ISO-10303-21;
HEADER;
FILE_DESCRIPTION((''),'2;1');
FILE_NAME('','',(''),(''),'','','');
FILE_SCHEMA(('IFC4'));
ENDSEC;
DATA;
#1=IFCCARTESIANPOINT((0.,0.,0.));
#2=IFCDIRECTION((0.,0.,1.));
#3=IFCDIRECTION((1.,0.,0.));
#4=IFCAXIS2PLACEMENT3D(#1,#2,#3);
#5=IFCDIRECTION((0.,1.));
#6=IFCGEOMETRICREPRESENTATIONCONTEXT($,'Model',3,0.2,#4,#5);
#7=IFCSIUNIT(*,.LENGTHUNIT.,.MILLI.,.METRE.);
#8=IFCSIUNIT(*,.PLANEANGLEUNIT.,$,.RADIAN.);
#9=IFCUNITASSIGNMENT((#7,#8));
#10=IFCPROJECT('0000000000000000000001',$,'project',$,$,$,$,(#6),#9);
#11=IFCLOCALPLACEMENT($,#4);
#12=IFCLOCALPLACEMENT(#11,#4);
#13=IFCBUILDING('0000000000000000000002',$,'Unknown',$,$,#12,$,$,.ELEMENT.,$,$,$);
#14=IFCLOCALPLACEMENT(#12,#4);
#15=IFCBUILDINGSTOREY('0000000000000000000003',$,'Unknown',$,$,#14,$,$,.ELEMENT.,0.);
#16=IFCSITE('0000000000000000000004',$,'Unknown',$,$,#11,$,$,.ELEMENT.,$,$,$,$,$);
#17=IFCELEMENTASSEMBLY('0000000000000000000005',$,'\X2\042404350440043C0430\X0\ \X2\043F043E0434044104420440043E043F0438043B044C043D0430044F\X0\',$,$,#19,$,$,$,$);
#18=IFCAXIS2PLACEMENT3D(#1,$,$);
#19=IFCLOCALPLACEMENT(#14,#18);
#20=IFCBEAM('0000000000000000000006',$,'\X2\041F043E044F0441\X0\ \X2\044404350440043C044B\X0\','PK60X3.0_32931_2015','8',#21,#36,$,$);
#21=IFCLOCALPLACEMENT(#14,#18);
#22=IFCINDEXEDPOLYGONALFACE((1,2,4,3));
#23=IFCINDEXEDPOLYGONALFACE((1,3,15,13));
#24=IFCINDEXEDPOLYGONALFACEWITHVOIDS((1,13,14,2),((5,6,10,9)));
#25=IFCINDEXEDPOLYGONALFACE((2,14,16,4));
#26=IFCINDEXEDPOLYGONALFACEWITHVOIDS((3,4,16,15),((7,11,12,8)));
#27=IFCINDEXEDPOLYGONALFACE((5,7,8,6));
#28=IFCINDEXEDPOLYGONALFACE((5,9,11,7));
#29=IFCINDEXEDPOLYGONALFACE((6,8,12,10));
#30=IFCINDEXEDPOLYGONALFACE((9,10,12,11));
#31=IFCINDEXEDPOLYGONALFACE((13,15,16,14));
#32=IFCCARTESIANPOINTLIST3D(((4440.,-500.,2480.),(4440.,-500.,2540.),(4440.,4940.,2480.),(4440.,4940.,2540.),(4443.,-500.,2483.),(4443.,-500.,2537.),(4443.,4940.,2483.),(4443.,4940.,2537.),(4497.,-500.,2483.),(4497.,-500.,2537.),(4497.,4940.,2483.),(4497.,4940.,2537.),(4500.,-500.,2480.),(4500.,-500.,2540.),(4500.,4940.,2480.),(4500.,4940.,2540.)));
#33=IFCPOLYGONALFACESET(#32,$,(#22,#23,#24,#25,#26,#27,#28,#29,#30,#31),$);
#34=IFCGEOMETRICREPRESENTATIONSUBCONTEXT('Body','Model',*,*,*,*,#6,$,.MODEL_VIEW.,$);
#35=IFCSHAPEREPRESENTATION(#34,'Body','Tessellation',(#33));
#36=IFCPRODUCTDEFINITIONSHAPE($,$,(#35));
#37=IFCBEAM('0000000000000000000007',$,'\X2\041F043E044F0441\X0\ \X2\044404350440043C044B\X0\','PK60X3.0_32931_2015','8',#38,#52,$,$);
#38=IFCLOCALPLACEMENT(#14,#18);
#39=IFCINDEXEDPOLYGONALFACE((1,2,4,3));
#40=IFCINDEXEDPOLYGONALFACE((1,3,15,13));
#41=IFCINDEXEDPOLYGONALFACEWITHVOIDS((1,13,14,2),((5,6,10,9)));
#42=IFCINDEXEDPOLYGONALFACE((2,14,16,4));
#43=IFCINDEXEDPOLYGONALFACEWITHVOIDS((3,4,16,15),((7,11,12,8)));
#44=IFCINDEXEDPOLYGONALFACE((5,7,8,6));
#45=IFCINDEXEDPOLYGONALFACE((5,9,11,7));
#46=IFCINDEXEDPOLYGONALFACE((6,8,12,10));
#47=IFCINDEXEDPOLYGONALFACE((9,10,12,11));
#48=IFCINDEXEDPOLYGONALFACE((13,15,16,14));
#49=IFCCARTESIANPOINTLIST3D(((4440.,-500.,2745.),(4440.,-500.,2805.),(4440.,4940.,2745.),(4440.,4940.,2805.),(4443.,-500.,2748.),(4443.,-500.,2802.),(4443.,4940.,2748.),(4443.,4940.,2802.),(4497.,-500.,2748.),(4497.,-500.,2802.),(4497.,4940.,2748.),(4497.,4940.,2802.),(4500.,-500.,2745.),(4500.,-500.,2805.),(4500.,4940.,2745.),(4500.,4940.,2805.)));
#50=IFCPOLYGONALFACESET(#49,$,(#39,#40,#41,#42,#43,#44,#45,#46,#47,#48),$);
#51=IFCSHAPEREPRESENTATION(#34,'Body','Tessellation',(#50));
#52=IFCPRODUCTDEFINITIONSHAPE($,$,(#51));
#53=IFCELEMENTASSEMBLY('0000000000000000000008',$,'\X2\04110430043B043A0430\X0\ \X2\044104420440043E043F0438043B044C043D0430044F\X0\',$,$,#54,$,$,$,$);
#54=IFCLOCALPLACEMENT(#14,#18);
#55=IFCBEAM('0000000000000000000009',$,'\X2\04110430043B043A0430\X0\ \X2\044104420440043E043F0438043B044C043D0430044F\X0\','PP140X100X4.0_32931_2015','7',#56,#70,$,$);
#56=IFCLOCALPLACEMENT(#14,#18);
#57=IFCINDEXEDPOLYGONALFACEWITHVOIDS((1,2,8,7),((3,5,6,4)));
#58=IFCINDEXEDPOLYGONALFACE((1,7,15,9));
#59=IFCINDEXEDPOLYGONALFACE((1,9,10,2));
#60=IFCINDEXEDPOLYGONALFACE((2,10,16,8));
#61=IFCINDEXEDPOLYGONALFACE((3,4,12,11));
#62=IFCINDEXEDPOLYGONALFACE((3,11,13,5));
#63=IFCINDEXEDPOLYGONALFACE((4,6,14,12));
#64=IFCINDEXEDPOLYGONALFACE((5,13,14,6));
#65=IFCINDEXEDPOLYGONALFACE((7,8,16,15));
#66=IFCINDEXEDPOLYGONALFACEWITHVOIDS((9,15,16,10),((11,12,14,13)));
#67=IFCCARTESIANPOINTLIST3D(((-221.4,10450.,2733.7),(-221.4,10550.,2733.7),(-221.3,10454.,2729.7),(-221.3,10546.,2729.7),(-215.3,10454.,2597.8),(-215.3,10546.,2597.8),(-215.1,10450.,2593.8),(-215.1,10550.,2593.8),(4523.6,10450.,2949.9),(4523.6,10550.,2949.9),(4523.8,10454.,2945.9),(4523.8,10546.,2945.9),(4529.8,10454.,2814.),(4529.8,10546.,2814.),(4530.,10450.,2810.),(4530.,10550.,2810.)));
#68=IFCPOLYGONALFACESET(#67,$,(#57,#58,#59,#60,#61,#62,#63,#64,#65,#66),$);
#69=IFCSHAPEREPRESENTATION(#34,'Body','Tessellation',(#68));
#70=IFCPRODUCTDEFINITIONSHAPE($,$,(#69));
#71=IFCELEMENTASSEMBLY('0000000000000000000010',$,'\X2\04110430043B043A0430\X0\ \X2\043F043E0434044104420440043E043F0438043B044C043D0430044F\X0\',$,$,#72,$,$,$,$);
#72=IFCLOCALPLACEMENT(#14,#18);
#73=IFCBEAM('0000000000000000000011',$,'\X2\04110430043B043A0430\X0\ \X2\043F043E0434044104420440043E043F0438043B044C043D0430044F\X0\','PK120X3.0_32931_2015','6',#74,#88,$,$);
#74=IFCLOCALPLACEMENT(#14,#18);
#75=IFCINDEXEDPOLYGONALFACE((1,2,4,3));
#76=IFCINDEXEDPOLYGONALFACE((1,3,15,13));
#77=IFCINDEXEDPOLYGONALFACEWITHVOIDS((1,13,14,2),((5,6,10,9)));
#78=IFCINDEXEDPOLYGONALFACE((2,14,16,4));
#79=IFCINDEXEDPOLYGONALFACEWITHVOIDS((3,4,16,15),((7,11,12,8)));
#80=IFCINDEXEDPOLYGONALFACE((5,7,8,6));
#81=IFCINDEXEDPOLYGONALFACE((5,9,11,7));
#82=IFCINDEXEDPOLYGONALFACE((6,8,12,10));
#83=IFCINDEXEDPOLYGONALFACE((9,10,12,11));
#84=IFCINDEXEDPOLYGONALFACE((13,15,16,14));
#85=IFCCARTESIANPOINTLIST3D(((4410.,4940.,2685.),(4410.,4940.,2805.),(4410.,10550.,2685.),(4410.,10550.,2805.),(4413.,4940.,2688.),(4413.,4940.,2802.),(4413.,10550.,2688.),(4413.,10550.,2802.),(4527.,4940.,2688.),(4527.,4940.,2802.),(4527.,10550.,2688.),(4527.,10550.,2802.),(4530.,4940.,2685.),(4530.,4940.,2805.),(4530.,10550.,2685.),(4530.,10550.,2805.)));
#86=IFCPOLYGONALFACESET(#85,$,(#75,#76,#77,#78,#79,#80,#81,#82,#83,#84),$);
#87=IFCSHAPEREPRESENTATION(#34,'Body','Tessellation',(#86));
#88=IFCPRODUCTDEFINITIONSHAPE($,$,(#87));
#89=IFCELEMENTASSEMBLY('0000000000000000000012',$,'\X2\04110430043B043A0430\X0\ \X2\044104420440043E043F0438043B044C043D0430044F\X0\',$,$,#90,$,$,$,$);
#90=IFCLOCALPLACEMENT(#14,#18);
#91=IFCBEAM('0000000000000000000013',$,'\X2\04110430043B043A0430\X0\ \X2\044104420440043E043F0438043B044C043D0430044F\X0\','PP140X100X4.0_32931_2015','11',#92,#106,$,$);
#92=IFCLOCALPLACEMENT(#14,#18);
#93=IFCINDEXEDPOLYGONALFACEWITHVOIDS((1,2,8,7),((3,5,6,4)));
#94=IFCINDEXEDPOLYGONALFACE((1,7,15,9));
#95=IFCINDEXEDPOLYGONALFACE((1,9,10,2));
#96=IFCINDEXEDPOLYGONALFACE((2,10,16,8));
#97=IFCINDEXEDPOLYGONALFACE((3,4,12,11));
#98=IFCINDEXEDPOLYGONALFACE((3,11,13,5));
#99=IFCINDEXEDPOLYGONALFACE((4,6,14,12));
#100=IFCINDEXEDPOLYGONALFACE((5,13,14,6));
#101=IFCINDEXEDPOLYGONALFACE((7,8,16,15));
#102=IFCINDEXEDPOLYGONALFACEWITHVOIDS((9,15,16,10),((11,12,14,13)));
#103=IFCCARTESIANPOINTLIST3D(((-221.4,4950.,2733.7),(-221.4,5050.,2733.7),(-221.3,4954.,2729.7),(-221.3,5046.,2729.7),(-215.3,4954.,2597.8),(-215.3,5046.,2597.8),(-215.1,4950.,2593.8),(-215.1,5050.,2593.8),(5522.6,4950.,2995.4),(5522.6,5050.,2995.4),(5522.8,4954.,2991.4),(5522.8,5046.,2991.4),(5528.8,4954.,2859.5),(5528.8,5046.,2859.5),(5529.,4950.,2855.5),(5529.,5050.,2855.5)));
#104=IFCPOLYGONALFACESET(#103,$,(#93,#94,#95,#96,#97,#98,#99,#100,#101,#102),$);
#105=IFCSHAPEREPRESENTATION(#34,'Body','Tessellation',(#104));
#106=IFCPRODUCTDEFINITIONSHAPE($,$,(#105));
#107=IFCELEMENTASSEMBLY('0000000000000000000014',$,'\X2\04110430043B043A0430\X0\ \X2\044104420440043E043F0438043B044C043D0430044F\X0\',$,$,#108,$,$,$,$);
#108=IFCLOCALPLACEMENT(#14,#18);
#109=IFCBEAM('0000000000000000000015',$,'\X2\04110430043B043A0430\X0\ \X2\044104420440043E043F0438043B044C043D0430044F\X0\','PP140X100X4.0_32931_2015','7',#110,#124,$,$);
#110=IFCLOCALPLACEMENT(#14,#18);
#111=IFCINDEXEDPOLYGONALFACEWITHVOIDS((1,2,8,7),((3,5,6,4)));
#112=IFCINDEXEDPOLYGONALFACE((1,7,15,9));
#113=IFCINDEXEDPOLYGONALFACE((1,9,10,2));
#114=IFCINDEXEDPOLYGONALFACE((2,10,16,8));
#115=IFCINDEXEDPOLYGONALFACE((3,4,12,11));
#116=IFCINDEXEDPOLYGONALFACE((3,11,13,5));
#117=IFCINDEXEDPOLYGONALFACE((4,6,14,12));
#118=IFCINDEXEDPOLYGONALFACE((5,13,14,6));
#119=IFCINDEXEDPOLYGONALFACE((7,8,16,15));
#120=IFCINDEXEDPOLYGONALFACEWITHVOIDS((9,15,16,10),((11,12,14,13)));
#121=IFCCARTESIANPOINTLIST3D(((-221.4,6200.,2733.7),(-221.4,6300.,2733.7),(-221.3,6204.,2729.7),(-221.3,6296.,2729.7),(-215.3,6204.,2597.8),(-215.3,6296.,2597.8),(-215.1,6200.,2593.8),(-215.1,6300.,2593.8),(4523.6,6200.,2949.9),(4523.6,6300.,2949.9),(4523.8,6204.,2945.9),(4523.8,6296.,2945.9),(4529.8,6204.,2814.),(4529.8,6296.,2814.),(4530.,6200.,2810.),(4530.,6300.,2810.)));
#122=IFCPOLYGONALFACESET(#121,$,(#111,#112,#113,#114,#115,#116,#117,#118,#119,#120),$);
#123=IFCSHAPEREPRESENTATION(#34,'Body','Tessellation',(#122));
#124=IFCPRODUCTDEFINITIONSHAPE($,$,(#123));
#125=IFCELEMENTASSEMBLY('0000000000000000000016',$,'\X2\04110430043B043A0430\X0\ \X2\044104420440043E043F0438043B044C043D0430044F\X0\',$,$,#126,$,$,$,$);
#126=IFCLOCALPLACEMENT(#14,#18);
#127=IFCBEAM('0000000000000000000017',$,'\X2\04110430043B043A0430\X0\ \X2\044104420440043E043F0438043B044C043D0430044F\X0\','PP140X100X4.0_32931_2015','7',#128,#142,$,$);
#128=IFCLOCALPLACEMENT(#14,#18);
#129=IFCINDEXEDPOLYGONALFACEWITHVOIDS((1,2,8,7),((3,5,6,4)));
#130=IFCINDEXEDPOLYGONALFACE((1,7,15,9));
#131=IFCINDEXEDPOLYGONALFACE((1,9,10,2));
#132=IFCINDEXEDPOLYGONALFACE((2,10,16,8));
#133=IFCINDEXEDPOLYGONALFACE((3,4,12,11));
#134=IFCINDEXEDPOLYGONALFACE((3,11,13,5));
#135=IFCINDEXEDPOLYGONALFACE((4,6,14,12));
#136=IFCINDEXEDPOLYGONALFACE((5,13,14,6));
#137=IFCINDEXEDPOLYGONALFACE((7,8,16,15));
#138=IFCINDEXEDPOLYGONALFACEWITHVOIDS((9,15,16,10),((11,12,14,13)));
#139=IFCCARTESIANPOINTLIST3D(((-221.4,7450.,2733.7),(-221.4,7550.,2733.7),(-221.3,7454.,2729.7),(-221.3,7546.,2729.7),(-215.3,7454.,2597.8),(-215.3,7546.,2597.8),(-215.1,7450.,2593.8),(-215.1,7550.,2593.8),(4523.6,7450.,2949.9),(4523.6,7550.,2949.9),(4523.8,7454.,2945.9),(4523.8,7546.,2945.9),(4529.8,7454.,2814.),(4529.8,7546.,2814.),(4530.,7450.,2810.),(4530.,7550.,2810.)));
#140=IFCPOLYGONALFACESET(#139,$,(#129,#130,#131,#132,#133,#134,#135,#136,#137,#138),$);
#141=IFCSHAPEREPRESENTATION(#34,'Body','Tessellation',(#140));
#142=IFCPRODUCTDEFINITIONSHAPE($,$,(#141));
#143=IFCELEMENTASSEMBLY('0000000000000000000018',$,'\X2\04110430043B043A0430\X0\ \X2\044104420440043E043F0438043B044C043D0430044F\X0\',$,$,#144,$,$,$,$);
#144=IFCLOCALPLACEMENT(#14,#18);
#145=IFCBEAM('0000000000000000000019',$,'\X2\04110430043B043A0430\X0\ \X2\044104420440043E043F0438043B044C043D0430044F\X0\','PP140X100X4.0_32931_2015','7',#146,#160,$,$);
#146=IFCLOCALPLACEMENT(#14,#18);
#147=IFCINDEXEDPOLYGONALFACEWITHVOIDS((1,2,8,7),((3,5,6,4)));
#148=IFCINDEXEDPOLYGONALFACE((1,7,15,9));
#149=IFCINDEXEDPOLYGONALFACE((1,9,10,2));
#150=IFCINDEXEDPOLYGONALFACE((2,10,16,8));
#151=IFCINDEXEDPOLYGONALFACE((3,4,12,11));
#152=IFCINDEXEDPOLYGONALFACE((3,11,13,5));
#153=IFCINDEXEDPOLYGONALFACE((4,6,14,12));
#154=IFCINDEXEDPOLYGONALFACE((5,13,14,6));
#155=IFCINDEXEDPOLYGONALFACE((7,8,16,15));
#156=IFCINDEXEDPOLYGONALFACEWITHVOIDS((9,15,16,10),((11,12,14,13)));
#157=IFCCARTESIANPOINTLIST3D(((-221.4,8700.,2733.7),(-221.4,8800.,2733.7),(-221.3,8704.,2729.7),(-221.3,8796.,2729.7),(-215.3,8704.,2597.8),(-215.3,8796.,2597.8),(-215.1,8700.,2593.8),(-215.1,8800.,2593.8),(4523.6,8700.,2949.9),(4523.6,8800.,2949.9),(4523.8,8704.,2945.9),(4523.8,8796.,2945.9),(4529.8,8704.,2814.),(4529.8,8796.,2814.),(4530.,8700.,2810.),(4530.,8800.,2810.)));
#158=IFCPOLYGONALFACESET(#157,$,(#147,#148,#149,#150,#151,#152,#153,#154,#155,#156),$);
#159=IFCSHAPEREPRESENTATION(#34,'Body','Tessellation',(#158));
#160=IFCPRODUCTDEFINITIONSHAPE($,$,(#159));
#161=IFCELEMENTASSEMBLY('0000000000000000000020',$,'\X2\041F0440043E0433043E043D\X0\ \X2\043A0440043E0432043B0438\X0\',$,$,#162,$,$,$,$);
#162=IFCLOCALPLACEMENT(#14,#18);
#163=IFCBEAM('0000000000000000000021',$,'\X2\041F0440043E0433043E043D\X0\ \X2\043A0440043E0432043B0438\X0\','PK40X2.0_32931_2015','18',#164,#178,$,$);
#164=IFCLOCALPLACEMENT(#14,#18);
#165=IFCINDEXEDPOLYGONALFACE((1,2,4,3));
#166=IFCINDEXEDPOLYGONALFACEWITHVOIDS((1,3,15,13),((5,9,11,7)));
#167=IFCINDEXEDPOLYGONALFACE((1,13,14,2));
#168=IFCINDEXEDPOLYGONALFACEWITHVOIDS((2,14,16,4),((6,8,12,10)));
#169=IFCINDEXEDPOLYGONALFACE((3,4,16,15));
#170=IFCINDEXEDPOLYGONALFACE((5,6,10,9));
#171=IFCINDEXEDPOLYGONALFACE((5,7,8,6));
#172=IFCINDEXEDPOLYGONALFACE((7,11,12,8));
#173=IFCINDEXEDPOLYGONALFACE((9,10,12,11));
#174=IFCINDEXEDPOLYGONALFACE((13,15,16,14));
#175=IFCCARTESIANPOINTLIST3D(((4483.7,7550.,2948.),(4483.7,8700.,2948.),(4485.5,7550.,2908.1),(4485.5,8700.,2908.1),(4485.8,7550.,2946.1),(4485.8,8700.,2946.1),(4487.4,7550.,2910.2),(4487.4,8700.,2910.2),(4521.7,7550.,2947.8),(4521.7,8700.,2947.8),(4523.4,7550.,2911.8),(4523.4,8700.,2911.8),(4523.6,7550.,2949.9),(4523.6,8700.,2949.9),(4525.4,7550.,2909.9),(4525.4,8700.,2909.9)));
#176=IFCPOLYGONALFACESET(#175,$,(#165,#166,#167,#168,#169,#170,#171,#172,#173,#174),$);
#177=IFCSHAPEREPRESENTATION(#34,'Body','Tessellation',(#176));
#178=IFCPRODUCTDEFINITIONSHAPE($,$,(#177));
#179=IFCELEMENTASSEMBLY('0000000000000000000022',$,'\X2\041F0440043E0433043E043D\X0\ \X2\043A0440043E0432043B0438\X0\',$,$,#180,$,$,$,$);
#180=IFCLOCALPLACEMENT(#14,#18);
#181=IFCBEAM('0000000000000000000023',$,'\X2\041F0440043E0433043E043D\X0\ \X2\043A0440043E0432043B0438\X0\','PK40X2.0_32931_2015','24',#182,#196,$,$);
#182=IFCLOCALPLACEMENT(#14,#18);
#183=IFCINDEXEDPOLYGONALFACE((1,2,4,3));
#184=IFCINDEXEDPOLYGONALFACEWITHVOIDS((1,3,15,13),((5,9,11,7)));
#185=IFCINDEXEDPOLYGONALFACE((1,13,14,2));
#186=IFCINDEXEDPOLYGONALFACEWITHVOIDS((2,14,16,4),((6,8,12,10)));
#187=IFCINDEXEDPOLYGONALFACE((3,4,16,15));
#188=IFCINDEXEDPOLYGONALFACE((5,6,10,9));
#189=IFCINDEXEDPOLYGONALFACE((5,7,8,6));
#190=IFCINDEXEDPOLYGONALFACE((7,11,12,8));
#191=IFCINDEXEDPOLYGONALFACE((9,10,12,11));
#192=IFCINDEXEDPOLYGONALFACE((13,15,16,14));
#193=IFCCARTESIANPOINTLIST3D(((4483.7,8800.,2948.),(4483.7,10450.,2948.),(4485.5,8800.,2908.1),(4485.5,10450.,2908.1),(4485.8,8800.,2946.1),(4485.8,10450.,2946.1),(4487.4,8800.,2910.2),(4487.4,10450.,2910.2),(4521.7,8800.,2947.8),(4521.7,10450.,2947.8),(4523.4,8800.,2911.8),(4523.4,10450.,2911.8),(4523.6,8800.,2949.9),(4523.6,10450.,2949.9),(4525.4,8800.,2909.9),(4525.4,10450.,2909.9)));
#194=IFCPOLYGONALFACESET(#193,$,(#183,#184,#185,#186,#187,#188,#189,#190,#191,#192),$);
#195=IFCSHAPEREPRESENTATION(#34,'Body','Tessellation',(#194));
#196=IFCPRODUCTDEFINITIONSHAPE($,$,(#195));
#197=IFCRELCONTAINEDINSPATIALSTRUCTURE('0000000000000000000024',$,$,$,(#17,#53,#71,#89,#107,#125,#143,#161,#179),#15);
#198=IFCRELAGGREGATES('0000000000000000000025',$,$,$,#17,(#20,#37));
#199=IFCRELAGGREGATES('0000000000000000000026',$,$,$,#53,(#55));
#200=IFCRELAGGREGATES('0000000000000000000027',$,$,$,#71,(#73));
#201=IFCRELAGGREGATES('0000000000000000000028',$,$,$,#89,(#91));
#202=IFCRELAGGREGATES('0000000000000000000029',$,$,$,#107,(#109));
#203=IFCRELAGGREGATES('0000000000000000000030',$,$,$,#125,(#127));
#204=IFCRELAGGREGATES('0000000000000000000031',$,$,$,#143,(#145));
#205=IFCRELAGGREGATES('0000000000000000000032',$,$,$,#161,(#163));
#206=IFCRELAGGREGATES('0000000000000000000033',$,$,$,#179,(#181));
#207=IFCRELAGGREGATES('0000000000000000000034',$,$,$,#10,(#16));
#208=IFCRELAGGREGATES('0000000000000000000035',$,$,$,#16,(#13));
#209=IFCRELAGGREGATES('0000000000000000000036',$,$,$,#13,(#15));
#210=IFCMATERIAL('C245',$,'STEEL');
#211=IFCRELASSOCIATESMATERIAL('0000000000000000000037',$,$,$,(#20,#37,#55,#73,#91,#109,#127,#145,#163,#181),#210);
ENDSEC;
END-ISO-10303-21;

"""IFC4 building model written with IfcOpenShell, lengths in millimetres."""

from ifc_helpers import new_model, si_unit, direction, frame, origin_with_axes, place, context, subcontext, project, spatial, line, indexed_curve, outline, extrude, material, element, aggregate, save


model = new_model("IFC4")

# Units and contexts
model_context = context("Model", 3, precision=0.2, world=origin_with_axes(), true_north=direction((0.0, 1.0)))
body_context = subcontext(model_context, "Body", "Model", "MODEL_VIEW")
ifc_project = project(units=[si_unit("LENGTHUNIT", "METRE", prefix="MILLI"), si_unit("PLANEANGLEUNIT", "RADIAN")], contexts=[model_context])

# Site, building, storey
site_placement = place(None, origin_with_axes())
site = spatial("IfcSite", under=ifc_project, at=site_placement, Name="Unknown", CompositionType="ELEMENT")
building_placement = place(site_placement, origin_with_axes())
building = spatial("IfcBuilding", under=site, at=building_placement, Name="Unknown", CompositionType="ELEMENT")
storey_placement = place(building_placement, origin_with_axes())
storey = spatial("IfcBuildingStorey", under=building, at=storey_placement, Name="Unknown", CompositionType="ELEMENT", Elevation=0.0)

# Shared definitions
ifc_material_1 = material(Name="C245", Category="STEEL")

# Element assembly, beams
assembly_1_placement = place(storey_placement, frame((4470.0, 4940.0, 2775.0), z_axis=(-1.0, 0.0, 0.0), x_axis=(0.0, -1.0, 0.0)))
assembly_1 = element("IfcElementAssembly", 1, at=assembly_1_placement, inside=storey, Name="Ферма подстропильная")
beam_1_placement = place(assembly_1_placement, frame((0.0, -265.0, 0.0), z_axis=(0.0, 0.0, 1.0), x_axis=(1.0, 0.0, 0.0)))
beam_1 = element("IfcBeam", 2, at=beam_1_placement, material=ifc_material_1, Name="Пояс фермы", Description="PK60X3.0_32931_2015", ObjectType="8", context=body_context, shape_type="SolidModel", body=[
    extrude(outline(indexed_curve([(-30.0, -30.0), (30.0, -30.0), (30.0, 30.0), (-30.0, 30.0)], segments=[line(1, 2, 3, 4, 1)]), holes=[indexed_curve([(-27.0, -27.0), (-27.0, 27.0), (27.0, 27.0), (27.0, -27.0)], segments=[line(1, 2, 3, 4, 1)])]), frame((0.0, 0.0, 0.0), z_axis=(-1.0, 0.0, 0.0), x_axis=(0.0, 0.0, 1.0)), (0.0, 0.0, -1.0), 5440.0),
])
beam_2_placement = place(assembly_1_placement, origin_with_axes())
beam_2 = element("IfcBeam", 3, at=beam_2_placement, material=ifc_material_1, Name="Пояс фермы", Description="PK60X3.0_32931_2015", ObjectType="8", context=body_context, shape_type="SolidModel", body=[
    extrude(outline(indexed_curve([(-30.0, -30.0), (30.0, -30.0), (30.0, 30.0), (-30.0, 30.0)], segments=[line(1, 2, 3, 4, 1)]), holes=[indexed_curve([(-27.0, -27.0), (-27.0, 27.0), (27.0, 27.0), (27.0, -27.0)], segments=[line(1, 2, 3, 4, 1)])]), frame((0.0, 0.0, 0.0), z_axis=(-1.0, 0.0, 0.0), x_axis=(0.0, 0.0, 1.0)), (0.0, 0.0, -1.0), 5440.0),
])
aggregate(assembly_1, [beam_1, beam_2])

# Element assemblies, beams
assembly_2_placement = place(storey_placement, frame((4526.8, 10500.0, 2879.9), z_axis=(0.0, 1.0, 0.0), x_axis=(-0.998964, 0.0, -0.045508)))
assembly_2 = element("IfcElementAssembly", 4, at=assembly_2_placement, inside=storey, Name="Балка стропильная")
beam_3_placement = place(assembly_2_placement, origin_with_axes())
beam_3 = element("IfcBeam", 5, at=beam_3_placement, material=ifc_material_1, Name="Балка стропильная", Description="PP140X100X4.0_32931_2015", ObjectType="7", context=body_context, shape_type="SolidModel", body=[
    extrude(outline(indexed_curve([(-50.0, -70.0), (50.0, -70.0), (50.0, 70.0), (-50.0, 70.0)], segments=[line(1, 2, 3, 4, 1)]), holes=[indexed_curve([(-46.0, -66.0), (-46.0, 66.0), (46.0, 66.0), (46.0, -66.0)], segments=[line(1, 2, 3, 4, 1)])]), frame((0.0, 0.0, 0.0), z_axis=(-1.0, 0.0, 0.0), x_axis=(0.0, 0.0, 1.0)), (0.0, 0.0, -1.0), 4750.0),
])
aggregate(assembly_2, [beam_3])
assembly_3_placement = place(storey_placement, frame((4470.0, 10550.0, 2745.0), z_axis=(-1.0, 0.0, 0.0), x_axis=(0.0, -1.0, 0.0)))
assembly_3 = element("IfcElementAssembly", 6, at=assembly_3_placement, inside=storey, Name="Балка подстропильная")
beam_4_placement = place(assembly_3_placement, origin_with_axes())
beam_4 = element("IfcBeam", 7, at=beam_4_placement, material=ifc_material_1, Name="Балка подстропильная", Description="PK120X3.0_32931_2015", ObjectType="6", context=body_context, shape_type="SolidModel", body=[
    extrude(outline(indexed_curve([(-60.0, -60.0), (60.0, -60.0), (60.0, 60.0), (-60.0, 60.0)], segments=[line(1, 2, 3, 4, 1)]), holes=[indexed_curve([(-57.0, -57.0), (-57.0, 57.0), (57.0, 57.0), (57.0, -57.0)], segments=[line(1, 2, 3, 4, 1)])]), frame((0.0, 0.0, 0.0), z_axis=(-1.0, 0.0, 0.0), x_axis=(0.0, 0.0, 1.0)), (0.0, 0.0, -1.0), 5610.0),
])
aggregate(assembly_3, [beam_4])
assembly_4_placement = place(storey_placement, frame((5525.8, 5000.0, 2925.4), z_axis=(0.0, 1.0, 0.0), x_axis=(-0.998964, 0.0, -0.045508)))
assembly_4 = element("IfcElementAssembly", 8, at=assembly_4_placement, inside=storey, Name="Балка стропильная")
beam_5_placement = place(assembly_4_placement, origin_with_axes())
beam_5 = element("IfcBeam", 9, at=beam_5_placement, material=ifc_material_1, Name="Балка стропильная", Description="PP140X100X4.0_32931_2015", ObjectType="11", context=body_context, shape_type="SolidModel", body=[
    extrude(outline(indexed_curve([(-50.0, -70.0), (50.0, -70.0), (50.0, 70.0), (-50.0, 70.0)], segments=[line(1, 2, 3, 4, 1)]), holes=[indexed_curve([(-46.0, -66.0), (-46.0, 66.0), (46.0, 66.0), (46.0, -66.0)], segments=[line(1, 2, 3, 4, 1)])]), frame((0.0, 0.0, 0.0), z_axis=(-1.0, 0.0, 0.0), x_axis=(0.0, 0.0, 1.0)), (0.0, 0.0, -1.0), 5750.0),
])
aggregate(assembly_4, [beam_5])
assembly_5_placement = place(storey_placement, frame((4526.8, 6250.0, 2879.9), z_axis=(0.0, 1.0, 0.0), x_axis=(-0.998964, 0.0, -0.045508)))
assembly_5 = element("IfcElementAssembly", 10, at=assembly_5_placement, inside=storey, Name="Балка стропильная")
beam_6_placement = place(assembly_5_placement, origin_with_axes())
beam_6 = element("IfcBeam", 11, at=beam_6_placement, material=ifc_material_1, Name="Балка стропильная", Description="PP140X100X4.0_32931_2015", ObjectType="7", context=body_context, shape_type="SolidModel", body=[
    extrude(outline(indexed_curve([(-50.0, -70.0), (50.0, -70.0), (50.0, 70.0), (-50.0, 70.0)], segments=[line(1, 2, 3, 4, 1)]), holes=[indexed_curve([(-46.0, -66.0), (-46.0, 66.0), (46.0, 66.0), (46.0, -66.0)], segments=[line(1, 2, 3, 4, 1)])]), frame((0.0, 0.0, 0.0), z_axis=(-1.0, 0.0, 0.0), x_axis=(0.0, 0.0, 1.0)), (0.0, 0.0, -1.0), 4750.0),
])
aggregate(assembly_5, [beam_6])
assembly_6_placement = place(storey_placement, frame((4526.8, 7500.0, 2879.9), z_axis=(0.0, 1.0, 0.0), x_axis=(-0.998964, 0.0, -0.045508)))
assembly_6 = element("IfcElementAssembly", 12, at=assembly_6_placement, inside=storey, Name="Балка стропильная")
beam_7_placement = place(assembly_6_placement, origin_with_axes())
beam_7 = element("IfcBeam", 13, at=beam_7_placement, material=ifc_material_1, Name="Балка стропильная", Description="PP140X100X4.0_32931_2015", ObjectType="7", context=body_context, shape_type="SolidModel", body=[
    extrude(outline(indexed_curve([(-50.0, -70.0), (50.0, -70.0), (50.0, 70.0), (-50.0, 70.0)], segments=[line(1, 2, 3, 4, 1)]), holes=[indexed_curve([(-46.0, -66.0), (-46.0, 66.0), (46.0, 66.0), (46.0, -66.0)], segments=[line(1, 2, 3, 4, 1)])]), frame((0.0, 0.0, 0.0), z_axis=(-1.0, 0.0, 0.0), x_axis=(0.0, 0.0, 1.0)), (0.0, 0.0, -1.0), 4750.0),
])
aggregate(assembly_6, [beam_7])
assembly_7_placement = place(storey_placement, frame((4526.8, 8750.0, 2879.9), z_axis=(0.0, 1.0, 0.0), x_axis=(-0.998964, 0.0, -0.045508)))
assembly_7 = element("IfcElementAssembly", 14, at=assembly_7_placement, inside=storey, Name="Балка стропильная")
beam_8_placement = place(assembly_7_placement, origin_with_axes())
beam_8 = element("IfcBeam", 15, at=beam_8_placement, material=ifc_material_1, Name="Балка стропильная", Description="PP140X100X4.0_32931_2015", ObjectType="7", context=body_context, shape_type="SolidModel", body=[
    extrude(outline(indexed_curve([(-50.0, -70.0), (50.0, -70.0), (50.0, 70.0), (-50.0, 70.0)], segments=[line(1, 2, 3, 4, 1)]), holes=[indexed_curve([(-46.0, -66.0), (-46.0, 66.0), (46.0, 66.0), (46.0, -66.0)], segments=[line(1, 2, 3, 4, 1)])]), frame((0.0, 0.0, 0.0), z_axis=(-1.0, 0.0, 0.0), x_axis=(0.0, 0.0, 1.0)), (0.0, 0.0, -1.0), 4750.0),
])
aggregate(assembly_7, [beam_8])
assembly_8_placement = place(storey_placement, frame((4504.6, 8700.0, 2929.0), z_axis=(-0.998964, 0.0, -0.045508), x_axis=(0.0, -1.0, 0.0)))
assembly_8 = element("IfcElementAssembly", 16, at=assembly_8_placement, inside=storey, Name="Прогон кровли")
beam_9_placement = place(assembly_8_placement, origin_with_axes())
beam_9 = element("IfcBeam", 17, at=beam_9_placement, material=ifc_material_1, Name="Прогон кровли", Description="PK40X2.0_32931_2015", ObjectType="18", context=body_context, shape_type="SolidModel", body=[
    extrude(outline(indexed_curve([(-20.0, -20.0), (20.0, -20.0), (20.0, 20.0), (-20.0, 20.0)], segments=[line(1, 2, 3, 4, 1)]), holes=[indexed_curve([(-18.0, -18.0), (-18.0, 18.0), (18.0, 18.0), (18.0, -18.0)], segments=[line(1, 2, 3, 4, 1)])]), frame((0.0, 0.0, 0.0), z_axis=(-1.0, 0.0, 0.0), x_axis=(0.0, 0.0, 1.0)), (0.0, 0.0, -1.0), 1150.0),
])
aggregate(assembly_8, [beam_9])
assembly_9_placement = place(storey_placement, frame((4504.6, 10450.0, 2929.0), z_axis=(-0.998964, 0.0, -0.045508), x_axis=(0.0, -1.0, 0.0)))
assembly_9 = element("IfcElementAssembly", 18, at=assembly_9_placement, inside=storey, Name="Прогон кровли")
beam_10_placement = place(assembly_9_placement, origin_with_axes())
beam_10 = element("IfcBeam", 19, at=beam_10_placement, material=ifc_material_1, Name="Прогон кровли", Description="PK40X2.0_32931_2015", ObjectType="24", context=body_context, shape_type="SolidModel", body=[
    extrude(outline(indexed_curve([(-20.0, -20.0), (20.0, -20.0), (20.0, 20.0), (-20.0, 20.0)], segments=[line(1, 2, 3, 4, 1)]), holes=[indexed_curve([(-18.0, -18.0), (-18.0, 18.0), (18.0, 18.0), (18.0, -18.0)], segments=[line(1, 2, 3, 4, 1)])]), frame((0.0, 0.0, 0.0), z_axis=(-1.0, 0.0, 0.0), x_axis=(0.0, 0.0, 1.0)), (0.0, 0.0, -1.0), 1650.0),
])
aggregate(assembly_9, [beam_10])

save(model, "model.ifc")
